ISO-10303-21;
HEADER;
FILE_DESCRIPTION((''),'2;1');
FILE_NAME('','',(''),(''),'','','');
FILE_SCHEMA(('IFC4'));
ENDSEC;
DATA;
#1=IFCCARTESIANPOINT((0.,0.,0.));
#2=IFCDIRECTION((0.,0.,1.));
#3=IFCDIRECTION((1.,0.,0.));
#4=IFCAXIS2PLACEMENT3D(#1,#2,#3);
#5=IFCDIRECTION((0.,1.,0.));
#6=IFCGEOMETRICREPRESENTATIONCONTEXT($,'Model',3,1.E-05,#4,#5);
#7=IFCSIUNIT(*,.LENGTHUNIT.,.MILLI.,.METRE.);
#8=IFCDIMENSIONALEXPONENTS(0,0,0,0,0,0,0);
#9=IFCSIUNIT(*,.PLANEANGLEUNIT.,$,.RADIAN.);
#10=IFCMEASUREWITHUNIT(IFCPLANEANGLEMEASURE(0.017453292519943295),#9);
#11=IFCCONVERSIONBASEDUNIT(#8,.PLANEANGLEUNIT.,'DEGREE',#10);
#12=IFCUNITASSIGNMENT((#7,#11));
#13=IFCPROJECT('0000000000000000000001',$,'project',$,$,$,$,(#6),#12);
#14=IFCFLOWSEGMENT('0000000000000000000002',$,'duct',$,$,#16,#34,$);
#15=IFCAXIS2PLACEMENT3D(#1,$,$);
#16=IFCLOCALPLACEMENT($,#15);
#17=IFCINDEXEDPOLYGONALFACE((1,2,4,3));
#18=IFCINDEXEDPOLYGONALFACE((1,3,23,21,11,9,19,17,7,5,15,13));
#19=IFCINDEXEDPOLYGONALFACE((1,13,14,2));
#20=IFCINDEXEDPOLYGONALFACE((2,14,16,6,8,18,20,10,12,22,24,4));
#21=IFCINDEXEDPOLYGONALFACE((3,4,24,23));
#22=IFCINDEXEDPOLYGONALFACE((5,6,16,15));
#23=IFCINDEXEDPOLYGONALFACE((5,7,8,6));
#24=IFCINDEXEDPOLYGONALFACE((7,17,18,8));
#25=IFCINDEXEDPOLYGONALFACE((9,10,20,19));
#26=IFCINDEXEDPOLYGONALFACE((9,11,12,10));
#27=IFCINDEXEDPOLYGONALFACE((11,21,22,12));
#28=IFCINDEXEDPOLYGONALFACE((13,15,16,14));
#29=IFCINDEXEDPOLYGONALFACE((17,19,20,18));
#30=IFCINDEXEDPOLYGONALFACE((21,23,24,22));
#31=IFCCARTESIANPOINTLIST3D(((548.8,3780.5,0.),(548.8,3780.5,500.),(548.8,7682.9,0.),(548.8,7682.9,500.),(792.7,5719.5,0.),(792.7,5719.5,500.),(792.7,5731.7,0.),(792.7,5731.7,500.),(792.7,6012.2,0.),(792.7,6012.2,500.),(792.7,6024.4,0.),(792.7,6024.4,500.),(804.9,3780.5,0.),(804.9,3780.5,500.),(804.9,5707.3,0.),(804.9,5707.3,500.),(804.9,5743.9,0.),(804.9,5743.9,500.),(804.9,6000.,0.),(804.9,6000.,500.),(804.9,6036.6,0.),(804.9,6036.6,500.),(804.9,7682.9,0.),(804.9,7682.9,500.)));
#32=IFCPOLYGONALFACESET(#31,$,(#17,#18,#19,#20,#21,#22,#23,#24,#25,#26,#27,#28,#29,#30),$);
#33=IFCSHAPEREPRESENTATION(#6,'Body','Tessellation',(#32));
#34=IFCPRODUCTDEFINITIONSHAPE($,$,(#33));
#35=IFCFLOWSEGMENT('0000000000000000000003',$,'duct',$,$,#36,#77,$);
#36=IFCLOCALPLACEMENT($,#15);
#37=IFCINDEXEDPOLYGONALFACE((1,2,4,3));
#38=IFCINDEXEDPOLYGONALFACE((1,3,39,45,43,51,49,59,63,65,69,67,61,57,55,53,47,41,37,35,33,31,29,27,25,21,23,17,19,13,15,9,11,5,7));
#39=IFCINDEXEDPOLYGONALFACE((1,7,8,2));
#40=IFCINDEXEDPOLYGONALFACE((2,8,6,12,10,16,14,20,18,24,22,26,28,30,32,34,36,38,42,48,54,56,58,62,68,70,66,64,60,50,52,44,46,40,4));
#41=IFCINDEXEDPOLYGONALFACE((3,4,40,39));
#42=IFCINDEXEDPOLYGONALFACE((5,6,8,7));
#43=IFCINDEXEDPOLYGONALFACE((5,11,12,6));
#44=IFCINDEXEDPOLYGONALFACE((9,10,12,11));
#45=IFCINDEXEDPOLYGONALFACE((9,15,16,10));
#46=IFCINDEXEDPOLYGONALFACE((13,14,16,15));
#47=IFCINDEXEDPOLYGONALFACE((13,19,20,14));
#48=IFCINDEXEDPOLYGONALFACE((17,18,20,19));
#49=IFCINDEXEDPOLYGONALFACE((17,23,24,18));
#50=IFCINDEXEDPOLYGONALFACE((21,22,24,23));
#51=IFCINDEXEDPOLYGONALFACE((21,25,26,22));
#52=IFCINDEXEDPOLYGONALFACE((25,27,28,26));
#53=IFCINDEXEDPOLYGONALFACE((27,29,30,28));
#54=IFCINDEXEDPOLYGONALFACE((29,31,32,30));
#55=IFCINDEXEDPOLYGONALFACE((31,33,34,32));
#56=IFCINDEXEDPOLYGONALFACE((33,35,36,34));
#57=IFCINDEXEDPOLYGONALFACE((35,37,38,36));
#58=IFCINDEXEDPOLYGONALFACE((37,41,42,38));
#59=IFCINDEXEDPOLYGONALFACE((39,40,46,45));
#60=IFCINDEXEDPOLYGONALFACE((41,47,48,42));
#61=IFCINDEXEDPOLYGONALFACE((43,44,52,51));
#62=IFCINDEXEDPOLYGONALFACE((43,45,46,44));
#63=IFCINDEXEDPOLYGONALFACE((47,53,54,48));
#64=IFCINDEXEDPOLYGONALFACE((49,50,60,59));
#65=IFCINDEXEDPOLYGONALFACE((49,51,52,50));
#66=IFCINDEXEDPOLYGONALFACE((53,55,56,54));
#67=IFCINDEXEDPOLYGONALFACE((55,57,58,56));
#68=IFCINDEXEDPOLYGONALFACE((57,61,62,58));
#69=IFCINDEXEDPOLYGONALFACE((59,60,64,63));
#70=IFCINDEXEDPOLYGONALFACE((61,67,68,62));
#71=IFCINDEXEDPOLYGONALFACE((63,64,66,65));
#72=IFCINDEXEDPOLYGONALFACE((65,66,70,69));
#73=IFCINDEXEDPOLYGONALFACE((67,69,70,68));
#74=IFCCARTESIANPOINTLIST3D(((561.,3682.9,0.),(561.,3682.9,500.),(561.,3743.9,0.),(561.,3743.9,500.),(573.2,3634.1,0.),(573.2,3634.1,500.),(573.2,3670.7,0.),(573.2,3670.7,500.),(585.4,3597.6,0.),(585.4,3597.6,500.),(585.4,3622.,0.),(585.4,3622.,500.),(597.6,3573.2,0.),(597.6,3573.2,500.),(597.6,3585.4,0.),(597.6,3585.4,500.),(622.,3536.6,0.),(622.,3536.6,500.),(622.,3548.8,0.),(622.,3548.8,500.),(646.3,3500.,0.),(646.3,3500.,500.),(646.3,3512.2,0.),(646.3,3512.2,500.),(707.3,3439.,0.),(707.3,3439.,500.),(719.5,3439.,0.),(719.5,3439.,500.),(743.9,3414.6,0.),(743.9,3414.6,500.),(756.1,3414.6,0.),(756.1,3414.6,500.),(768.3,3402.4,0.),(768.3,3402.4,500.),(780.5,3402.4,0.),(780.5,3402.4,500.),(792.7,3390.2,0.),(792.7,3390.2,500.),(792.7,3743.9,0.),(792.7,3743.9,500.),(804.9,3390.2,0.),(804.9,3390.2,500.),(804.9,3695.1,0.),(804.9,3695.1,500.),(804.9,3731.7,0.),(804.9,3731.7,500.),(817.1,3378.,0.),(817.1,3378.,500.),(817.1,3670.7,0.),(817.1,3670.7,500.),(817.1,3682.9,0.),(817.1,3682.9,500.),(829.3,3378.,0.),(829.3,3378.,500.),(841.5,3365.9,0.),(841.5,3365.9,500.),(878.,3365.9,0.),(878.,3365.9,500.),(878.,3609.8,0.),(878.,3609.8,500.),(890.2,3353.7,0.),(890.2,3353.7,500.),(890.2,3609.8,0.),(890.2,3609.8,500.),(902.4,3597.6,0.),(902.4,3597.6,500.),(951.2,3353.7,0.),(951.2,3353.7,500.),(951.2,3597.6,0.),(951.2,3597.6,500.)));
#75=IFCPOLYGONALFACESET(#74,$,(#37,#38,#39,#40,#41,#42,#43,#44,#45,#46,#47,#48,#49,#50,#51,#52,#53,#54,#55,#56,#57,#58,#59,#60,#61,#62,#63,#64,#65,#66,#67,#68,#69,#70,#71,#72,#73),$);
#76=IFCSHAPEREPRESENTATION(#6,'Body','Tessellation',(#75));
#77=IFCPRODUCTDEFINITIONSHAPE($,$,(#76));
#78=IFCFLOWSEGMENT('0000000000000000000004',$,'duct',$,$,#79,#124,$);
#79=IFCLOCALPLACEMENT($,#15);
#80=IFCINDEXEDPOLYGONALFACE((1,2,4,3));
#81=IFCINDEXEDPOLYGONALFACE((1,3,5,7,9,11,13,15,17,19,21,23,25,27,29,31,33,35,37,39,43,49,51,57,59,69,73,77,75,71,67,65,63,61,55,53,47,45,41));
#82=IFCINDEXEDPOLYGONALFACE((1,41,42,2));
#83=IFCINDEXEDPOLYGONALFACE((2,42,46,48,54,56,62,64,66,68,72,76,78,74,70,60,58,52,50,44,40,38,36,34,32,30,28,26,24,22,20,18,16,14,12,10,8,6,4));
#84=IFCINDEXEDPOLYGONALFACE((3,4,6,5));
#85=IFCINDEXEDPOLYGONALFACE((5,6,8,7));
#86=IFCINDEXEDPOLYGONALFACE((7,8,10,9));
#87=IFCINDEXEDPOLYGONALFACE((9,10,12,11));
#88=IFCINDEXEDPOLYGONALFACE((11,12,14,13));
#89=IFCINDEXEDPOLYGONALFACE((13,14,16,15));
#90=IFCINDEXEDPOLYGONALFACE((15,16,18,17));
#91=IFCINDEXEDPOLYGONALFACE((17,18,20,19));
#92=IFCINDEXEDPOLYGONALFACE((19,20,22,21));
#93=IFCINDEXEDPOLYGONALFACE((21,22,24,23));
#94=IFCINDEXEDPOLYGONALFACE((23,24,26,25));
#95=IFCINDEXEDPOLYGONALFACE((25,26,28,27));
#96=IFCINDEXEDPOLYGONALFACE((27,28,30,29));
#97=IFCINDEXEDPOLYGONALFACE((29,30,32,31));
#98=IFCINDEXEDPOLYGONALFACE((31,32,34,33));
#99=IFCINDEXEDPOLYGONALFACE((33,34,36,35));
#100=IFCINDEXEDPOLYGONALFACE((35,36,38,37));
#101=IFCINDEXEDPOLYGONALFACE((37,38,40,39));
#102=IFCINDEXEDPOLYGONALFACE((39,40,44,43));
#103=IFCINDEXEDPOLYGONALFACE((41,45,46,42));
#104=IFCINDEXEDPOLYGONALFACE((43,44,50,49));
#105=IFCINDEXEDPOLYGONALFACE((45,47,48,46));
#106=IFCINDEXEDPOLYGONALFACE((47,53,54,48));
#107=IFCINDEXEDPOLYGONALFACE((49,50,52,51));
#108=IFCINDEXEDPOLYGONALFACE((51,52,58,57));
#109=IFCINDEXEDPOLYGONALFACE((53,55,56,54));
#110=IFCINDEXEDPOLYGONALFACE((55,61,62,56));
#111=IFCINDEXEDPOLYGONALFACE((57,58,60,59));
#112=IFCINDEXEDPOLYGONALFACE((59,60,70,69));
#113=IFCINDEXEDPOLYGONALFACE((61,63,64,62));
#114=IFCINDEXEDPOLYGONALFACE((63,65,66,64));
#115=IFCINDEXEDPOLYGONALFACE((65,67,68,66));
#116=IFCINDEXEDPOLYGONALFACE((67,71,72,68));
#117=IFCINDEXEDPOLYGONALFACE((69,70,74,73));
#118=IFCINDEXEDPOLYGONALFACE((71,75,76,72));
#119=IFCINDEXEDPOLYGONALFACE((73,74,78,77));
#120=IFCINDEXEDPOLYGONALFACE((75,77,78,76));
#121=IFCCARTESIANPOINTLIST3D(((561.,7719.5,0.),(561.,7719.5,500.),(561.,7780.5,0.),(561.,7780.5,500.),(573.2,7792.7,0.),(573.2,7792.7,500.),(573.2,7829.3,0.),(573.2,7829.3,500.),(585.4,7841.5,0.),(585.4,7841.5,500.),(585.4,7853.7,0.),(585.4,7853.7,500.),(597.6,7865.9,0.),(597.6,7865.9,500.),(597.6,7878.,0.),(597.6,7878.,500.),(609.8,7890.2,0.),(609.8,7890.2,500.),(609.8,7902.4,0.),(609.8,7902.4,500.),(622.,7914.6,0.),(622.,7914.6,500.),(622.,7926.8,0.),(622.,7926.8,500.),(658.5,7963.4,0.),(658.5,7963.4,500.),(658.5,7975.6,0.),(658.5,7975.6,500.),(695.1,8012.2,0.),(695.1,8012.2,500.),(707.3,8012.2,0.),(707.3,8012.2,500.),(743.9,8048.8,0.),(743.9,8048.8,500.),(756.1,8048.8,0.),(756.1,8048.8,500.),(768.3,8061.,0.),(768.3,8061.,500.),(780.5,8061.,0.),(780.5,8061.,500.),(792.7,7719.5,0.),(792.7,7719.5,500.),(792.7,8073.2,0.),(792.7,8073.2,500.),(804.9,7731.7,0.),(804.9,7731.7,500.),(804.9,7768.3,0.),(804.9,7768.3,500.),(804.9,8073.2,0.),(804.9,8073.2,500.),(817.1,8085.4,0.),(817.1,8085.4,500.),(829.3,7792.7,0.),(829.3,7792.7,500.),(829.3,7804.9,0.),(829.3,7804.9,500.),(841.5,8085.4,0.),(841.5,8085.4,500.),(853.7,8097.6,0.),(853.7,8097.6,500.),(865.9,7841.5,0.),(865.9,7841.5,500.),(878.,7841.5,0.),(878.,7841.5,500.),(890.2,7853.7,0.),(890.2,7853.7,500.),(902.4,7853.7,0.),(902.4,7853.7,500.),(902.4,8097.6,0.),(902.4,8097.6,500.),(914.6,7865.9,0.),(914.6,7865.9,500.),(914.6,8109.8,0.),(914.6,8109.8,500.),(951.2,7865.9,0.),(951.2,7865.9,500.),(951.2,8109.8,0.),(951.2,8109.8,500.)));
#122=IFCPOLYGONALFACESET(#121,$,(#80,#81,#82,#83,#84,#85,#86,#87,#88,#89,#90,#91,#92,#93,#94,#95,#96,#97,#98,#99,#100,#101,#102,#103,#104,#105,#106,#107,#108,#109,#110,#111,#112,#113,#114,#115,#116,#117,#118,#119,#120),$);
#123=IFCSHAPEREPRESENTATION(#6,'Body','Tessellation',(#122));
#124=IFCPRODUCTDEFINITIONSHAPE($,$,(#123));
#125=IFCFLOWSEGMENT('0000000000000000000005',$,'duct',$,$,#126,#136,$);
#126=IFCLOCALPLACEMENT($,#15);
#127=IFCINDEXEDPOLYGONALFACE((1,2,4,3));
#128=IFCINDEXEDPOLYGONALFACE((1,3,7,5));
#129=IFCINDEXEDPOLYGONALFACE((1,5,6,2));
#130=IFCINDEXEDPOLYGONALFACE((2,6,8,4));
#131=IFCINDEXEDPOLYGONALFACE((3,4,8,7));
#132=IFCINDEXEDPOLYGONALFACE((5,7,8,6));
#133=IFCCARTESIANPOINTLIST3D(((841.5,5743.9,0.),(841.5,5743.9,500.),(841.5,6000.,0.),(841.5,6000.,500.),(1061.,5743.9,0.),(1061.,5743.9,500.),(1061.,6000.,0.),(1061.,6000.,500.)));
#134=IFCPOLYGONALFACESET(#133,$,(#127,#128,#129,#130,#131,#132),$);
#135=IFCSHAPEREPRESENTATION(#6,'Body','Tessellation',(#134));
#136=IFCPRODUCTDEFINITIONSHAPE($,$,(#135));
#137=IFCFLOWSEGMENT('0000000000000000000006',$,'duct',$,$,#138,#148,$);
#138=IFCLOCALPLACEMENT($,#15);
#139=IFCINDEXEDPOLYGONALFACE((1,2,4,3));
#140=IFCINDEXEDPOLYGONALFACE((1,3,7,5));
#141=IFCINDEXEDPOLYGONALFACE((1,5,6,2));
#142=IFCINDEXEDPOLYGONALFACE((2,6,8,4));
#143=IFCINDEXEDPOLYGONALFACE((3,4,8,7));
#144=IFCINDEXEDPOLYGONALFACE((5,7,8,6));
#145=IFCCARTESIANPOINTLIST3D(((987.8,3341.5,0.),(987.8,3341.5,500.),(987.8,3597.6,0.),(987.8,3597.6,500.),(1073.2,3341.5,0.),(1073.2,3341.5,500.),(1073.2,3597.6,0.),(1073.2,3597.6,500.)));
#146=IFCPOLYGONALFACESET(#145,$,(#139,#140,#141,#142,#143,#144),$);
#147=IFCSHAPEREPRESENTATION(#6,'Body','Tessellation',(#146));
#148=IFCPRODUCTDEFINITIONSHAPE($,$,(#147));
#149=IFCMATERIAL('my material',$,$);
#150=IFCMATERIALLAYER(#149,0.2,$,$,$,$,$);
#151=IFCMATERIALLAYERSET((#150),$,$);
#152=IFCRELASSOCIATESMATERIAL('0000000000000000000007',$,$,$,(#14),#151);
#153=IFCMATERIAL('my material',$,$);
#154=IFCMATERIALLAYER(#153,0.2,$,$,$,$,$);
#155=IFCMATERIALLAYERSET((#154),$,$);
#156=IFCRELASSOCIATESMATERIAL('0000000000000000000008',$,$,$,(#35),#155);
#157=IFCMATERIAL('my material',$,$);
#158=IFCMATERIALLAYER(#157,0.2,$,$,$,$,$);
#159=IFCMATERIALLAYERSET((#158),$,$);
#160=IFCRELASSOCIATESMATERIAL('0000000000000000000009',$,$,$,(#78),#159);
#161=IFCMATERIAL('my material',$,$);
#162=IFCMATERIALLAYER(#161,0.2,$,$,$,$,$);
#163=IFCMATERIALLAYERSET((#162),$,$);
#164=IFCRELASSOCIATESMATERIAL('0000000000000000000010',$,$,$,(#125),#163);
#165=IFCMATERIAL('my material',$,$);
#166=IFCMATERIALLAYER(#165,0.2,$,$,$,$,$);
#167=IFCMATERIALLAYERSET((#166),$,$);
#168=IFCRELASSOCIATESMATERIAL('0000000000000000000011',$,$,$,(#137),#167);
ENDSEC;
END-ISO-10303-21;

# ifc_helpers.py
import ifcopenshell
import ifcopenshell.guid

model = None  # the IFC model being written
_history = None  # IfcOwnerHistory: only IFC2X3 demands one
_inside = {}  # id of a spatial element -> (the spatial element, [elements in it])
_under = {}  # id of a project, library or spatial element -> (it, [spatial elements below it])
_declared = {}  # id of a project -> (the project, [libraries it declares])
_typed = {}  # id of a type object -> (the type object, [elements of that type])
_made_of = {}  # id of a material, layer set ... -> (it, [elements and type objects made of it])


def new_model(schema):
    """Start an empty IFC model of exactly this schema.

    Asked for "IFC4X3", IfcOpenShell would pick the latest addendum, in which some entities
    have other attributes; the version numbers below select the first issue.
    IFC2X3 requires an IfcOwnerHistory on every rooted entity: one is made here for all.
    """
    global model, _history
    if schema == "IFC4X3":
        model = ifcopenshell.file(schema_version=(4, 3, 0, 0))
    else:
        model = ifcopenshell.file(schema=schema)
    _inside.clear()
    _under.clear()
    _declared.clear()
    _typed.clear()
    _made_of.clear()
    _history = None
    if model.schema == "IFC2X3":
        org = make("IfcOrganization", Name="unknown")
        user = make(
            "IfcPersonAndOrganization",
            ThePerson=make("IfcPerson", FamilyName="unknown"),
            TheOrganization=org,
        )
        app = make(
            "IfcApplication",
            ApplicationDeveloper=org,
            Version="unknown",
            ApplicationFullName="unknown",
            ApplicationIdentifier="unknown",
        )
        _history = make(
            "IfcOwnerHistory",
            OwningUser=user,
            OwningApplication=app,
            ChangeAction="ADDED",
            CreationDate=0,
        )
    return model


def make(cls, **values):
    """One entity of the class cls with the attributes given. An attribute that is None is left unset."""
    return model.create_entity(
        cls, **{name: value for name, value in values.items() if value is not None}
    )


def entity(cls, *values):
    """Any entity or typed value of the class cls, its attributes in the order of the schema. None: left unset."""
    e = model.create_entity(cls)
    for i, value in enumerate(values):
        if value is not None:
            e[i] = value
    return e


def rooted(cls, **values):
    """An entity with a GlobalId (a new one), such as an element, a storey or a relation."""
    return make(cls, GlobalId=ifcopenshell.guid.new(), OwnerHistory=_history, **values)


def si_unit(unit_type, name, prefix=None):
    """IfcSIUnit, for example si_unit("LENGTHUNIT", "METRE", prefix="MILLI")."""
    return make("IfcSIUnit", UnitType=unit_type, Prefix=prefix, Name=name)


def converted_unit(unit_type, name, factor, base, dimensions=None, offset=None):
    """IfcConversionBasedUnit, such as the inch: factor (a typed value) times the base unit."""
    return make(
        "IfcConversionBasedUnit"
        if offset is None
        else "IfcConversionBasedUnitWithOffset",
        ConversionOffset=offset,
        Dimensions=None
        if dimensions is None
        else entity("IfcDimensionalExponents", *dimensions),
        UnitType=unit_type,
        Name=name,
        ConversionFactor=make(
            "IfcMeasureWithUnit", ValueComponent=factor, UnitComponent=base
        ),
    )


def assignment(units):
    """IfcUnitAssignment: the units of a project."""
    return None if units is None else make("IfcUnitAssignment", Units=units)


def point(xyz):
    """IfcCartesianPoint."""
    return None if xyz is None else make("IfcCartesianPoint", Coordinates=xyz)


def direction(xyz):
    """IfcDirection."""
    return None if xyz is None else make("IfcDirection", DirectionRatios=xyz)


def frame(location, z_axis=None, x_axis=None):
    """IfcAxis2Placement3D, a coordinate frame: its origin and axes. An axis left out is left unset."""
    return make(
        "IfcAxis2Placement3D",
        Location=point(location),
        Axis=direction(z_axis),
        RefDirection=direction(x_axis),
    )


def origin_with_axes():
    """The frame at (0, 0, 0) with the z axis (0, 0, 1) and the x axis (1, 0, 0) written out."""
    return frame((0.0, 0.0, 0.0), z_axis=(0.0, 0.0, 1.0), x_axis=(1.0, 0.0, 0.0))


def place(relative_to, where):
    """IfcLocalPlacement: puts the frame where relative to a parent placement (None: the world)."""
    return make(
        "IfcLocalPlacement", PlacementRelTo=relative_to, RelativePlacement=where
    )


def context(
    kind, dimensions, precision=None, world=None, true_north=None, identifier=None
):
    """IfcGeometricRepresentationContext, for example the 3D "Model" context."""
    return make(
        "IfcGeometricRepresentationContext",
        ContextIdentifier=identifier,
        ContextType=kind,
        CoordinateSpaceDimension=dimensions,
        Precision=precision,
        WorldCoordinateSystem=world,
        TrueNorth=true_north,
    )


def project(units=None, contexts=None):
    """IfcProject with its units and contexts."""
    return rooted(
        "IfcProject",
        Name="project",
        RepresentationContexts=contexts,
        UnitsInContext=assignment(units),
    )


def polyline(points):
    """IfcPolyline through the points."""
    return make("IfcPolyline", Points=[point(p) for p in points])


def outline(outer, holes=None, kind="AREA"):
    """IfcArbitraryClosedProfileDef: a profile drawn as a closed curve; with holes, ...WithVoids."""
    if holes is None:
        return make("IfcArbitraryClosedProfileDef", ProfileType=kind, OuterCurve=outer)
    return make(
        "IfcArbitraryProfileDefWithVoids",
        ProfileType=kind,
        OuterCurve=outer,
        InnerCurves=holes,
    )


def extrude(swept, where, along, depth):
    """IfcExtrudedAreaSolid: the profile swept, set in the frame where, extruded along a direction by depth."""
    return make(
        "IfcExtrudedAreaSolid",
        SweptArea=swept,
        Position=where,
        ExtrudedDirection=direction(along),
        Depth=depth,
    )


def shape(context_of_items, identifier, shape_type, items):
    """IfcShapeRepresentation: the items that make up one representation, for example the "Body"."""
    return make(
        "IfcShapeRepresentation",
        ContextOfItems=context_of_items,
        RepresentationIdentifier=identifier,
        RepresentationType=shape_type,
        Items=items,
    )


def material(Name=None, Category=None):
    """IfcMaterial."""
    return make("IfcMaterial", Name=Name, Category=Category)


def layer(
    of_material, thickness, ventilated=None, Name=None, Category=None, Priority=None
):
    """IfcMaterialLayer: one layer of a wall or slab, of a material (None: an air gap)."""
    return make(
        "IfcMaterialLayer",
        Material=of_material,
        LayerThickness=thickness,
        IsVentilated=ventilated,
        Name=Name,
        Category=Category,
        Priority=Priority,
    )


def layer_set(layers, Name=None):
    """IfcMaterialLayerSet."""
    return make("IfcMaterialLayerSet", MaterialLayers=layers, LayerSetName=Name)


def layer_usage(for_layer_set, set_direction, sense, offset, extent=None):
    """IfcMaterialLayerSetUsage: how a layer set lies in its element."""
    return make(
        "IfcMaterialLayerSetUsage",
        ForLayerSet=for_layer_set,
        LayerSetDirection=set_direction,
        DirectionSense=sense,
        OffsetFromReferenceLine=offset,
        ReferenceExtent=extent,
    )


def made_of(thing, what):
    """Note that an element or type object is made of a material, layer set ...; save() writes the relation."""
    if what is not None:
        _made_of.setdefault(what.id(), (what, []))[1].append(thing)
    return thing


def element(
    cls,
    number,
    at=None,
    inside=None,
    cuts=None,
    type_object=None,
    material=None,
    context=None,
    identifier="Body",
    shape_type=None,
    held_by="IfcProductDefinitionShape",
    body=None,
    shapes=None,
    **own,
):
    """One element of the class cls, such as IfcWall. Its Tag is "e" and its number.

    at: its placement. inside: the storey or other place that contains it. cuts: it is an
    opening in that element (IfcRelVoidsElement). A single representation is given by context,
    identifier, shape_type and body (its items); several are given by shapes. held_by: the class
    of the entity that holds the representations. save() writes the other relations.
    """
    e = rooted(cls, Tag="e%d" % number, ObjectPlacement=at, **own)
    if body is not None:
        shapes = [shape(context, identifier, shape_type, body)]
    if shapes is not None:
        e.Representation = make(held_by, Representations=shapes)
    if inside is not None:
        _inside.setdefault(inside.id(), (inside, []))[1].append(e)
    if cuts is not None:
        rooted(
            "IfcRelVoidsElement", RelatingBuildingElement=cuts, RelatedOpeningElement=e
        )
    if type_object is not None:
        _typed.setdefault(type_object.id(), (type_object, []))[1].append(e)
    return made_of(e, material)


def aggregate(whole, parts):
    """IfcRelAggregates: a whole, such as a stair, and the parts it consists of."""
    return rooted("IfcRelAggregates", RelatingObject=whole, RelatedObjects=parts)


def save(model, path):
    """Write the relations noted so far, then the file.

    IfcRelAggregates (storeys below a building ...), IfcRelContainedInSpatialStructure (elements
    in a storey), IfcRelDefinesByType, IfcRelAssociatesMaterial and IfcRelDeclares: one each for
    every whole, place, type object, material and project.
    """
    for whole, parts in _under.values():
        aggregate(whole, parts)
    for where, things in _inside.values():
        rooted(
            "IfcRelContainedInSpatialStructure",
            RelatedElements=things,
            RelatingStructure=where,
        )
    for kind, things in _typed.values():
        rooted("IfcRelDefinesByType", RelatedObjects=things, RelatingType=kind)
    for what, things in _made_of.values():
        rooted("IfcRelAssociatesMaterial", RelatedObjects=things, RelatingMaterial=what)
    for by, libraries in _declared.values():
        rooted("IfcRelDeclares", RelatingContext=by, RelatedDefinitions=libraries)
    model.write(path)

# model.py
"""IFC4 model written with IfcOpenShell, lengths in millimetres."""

from ifc_helpers import new_model, entity, si_unit, converted_unit, direction, origin_with_axes, place, context, project, polyline, outline, extrude, material, layer, layer_set, layer_usage, element, save


model = new_model("IFC4")

# Units and contexts
model_context = context("Model", 3, precision=1e-05, world=origin_with_axes(), true_north=direction((0.0, 1.0, 0.0)))
ifc_project = project(units=[si_unit("LENGTHUNIT", "METRE", prefix="MILLI"), converted_unit("PLANEANGLEUNIT", "DEGREE", entity("IfcPlaneAngleMeasure", 0.017453292519943295), si_unit("PLANEANGLEUNIT", "RADIAN"), dimensions=[0, 0, 0, 0, 0, 0, 0])], contexts=[model_context])

# Flow segments
ifc_material_1 = material(Name="my material")
ifc_layer_1 = layer(ifc_material_1, 0.2)
ifc_layer_set_1 = layer_set([ifc_layer_1])
ifc_layer_usage_1 = layer_usage(ifc_layer_set_1, "AXIS2", "POSITIVE", -0.1)
flow_segment_1_placement = place(None, origin_with_axes())
element("IfcFlowSegment", 1, at=flow_segment_1_placement, material=ifc_layer_usage_1, Name="duct", context=model_context, shape_type="SweptSolid", body=[
    extrude(outline(polyline([(548.8, 3780.5), (804.9, 3780.5), (804.9, 5707.3), (792.7, 5719.5), (792.7, 5731.7), (804.9, 5743.9), (804.9, 6000.0), (792.7, 6012.2), (792.7, 6024.4), (804.9, 6036.6), (804.9, 7682.9), (548.8, 7682.9), (548.8, 3780.5)])), origin_with_axes(), (0.0, 0.0, 1.0), 500.0),
])
ifc_material_2 = material(Name="my material")
ifc_layer_2 = layer(ifc_material_2, 0.2)
ifc_layer_set_2 = layer_set([ifc_layer_2])
ifc_layer_usage_2 = layer_usage(ifc_layer_set_2, "AXIS2", "POSITIVE", -0.1)
flow_segment_2_placement = place(None, origin_with_axes())
element("IfcFlowSegment", 2, at=flow_segment_2_placement, material=ifc_layer_usage_2, Name="duct", context=model_context, shape_type="SweptSolid", body=[
    extrude(outline(polyline([(561.0, 3682.9), (573.2, 3670.7), (573.2, 3634.1), (585.4, 3622.0), (585.4, 3597.6), (597.6, 3585.4), (597.6, 3573.2), (622.0, 3548.8), (622.0, 3536.6), (646.3, 3512.2), (646.3, 3500.0), (707.3, 3439.0), (719.5, 3439.0), (743.9, 3414.6), (756.1, 3414.6), (768.3, 3402.4), (780.5, 3402.4), (792.7, 3390.2), (804.9, 3390.2), (817.1, 3378.0), (829.3, 3378.0), (841.5, 3365.9), (878.0, 3365.9), (890.2, 3353.7), (951.2, 3353.7), (951.2, 3597.6), (902.4, 3597.6), (890.2, 3609.8), (878.0, 3609.8), (817.1, 3670.7), (817.1, 3682.9), (804.9, 3695.1), (804.9, 3731.7), (792.7, 3743.9), (561.0, 3743.9), (561.0, 3682.9)])), origin_with_axes(), (0.0, 0.0, 1.0), 500.0),
])
ifc_material_3 = material(Name="my material")
ifc_layer_3 = layer(ifc_material_3, 0.2)
ifc_layer_set_3 = layer_set([ifc_layer_3])
ifc_layer_usage_3 = layer_usage(ifc_layer_set_3, "AXIS2", "POSITIVE", -0.1)
flow_segment_3_placement = place(None, origin_with_axes())
element("IfcFlowSegment", 3, at=flow_segment_3_placement, material=ifc_layer_usage_3, Name="duct", context=model_context, shape_type="SweptSolid", body=[
    extrude(outline(polyline([(561.0, 7719.5), (792.7, 7719.5), (804.9, 7731.7), (804.9, 7768.3), (829.3, 7792.7), (829.3, 7804.9), (865.9, 7841.5), (878.0, 7841.5), (890.2, 7853.7), (902.4, 7853.7), (914.6, 7865.9), (951.2, 7865.9), (951.2, 8109.8), (914.6, 8109.8), (902.4, 8097.6), (853.7, 8097.6), (841.5, 8085.4), (817.1, 8085.4), (804.9, 8073.2), (792.7, 8073.2), (780.5, 8061.0), (768.3, 8061.0), (756.1, 8048.8), (743.9, 8048.8), (707.3, 8012.2), (695.1, 8012.2), (658.5, 7975.6), (658.5, 7963.4), (622.0, 7926.8), (622.0, 7914.6), (609.8, 7902.4), (609.8, 7890.2), (597.6, 7878.0), (597.6, 7865.9), (585.4, 7853.7), (585.4, 7841.5), (573.2, 7829.3), (573.2, 7792.7), (561.0, 7780.5), (561.0, 7719.5)])), origin_with_axes(), (0.0, 0.0, 1.0), 500.0),
])
ifc_material_4 = material(Name="my material")
ifc_layer_4 = layer(ifc_material_4, 0.2)
ifc_layer_set_4 = layer_set([ifc_layer_4])
ifc_layer_usage_4 = layer_usage(ifc_layer_set_4, "AXIS2", "POSITIVE", -0.1)
flow_segment_4_placement = place(None, origin_with_axes())
element("IfcFlowSegment", 4, at=flow_segment_4_placement, material=ifc_layer_usage_4, Name="duct", context=model_context, shape_type="SweptSolid", body=[
    extrude(outline(polyline([(841.5, 5743.9), (1061.0, 5743.9), (1061.0, 6000.0), (841.5, 6000.0), (841.5, 5743.9)])), origin_with_axes(), (0.0, 0.0, 1.0), 500.0),
])
ifc_material_5 = material(Name="my material")
ifc_layer_5 = layer(ifc_material_5, 0.2)
ifc_layer_set_5 = layer_set([ifc_layer_5])
ifc_layer_usage_5 = layer_usage(ifc_layer_set_5, "AXIS2", "POSITIVE", -0.1)
flow_segment_5_placement = place(None, origin_with_axes())
element("IfcFlowSegment", 5, at=flow_segment_5_placement, material=ifc_layer_usage_5, Name="duct", context=model_context, shape_type="SweptSolid", body=[
    extrude(outline(polyline([(987.8, 3341.5), (1073.2, 3341.5), (1073.2, 3597.6), (987.8, 3597.6), (987.8, 3341.5)])), origin_with_axes(), (0.0, 0.0, 1.0), 500.0),
])

save(model, "model.ifc")
